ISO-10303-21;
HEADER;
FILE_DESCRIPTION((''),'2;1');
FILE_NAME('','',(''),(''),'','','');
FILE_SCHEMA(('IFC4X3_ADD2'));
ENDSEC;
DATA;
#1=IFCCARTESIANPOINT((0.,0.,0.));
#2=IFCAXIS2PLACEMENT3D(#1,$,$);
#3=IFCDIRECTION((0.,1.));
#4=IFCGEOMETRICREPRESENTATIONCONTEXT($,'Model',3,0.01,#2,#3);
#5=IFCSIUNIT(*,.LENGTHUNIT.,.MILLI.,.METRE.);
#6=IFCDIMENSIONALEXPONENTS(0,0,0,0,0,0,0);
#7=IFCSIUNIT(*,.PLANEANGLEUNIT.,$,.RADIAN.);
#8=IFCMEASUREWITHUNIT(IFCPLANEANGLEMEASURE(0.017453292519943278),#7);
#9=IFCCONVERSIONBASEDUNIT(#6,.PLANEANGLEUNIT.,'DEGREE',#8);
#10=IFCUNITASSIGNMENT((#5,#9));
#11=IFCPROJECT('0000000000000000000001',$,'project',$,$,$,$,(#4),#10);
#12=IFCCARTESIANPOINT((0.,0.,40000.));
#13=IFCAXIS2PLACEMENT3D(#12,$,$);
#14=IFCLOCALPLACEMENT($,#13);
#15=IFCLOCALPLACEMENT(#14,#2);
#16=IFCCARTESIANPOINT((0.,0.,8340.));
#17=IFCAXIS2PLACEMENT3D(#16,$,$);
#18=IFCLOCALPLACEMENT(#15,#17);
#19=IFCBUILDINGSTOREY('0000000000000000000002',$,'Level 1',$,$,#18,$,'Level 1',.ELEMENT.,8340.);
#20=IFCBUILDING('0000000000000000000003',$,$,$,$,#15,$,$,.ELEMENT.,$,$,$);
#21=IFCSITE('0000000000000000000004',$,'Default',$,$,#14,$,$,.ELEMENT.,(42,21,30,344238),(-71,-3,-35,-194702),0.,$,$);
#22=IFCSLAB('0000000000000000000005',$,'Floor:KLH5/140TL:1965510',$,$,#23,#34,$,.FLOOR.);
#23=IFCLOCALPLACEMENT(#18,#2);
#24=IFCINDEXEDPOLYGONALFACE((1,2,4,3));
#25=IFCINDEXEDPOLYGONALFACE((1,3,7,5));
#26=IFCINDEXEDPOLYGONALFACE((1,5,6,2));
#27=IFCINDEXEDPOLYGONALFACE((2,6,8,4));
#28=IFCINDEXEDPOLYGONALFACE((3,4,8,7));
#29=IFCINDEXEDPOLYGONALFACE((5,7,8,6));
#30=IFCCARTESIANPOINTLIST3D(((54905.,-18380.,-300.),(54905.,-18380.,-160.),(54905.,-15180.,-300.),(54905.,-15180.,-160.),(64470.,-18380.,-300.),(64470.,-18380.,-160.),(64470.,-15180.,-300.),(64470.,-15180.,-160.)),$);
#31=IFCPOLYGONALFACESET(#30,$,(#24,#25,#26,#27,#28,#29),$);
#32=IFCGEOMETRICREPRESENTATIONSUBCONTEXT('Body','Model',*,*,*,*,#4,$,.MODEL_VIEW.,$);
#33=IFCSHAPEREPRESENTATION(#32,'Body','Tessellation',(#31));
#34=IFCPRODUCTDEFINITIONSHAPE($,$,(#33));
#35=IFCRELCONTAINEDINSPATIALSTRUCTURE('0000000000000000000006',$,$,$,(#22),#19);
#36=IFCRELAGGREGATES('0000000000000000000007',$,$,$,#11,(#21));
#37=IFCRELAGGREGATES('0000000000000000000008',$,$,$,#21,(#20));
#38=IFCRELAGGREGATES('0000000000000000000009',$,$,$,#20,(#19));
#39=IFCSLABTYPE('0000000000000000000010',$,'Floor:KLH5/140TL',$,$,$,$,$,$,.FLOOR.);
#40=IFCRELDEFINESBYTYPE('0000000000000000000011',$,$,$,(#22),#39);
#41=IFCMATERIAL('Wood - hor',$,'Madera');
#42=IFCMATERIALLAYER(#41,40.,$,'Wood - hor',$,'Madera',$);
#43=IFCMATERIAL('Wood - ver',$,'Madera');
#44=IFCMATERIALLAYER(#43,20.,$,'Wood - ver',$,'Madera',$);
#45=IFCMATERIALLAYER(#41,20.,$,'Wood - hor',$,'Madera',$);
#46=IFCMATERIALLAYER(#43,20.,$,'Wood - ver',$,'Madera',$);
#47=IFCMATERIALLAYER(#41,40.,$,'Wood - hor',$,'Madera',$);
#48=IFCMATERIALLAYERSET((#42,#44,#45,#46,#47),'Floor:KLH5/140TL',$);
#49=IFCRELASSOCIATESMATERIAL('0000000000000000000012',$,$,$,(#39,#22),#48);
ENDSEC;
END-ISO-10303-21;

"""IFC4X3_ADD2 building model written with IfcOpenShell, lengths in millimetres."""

from ifc_helpers import new_model, entity, si_unit, converted_unit, direction, frame, frame_2d, origin, place, context, subcontext, project, spatial, rectangle, extrude, material, layer, layer_set, layer_usage, type_object, element, save


model = new_model("IFC4X3_ADD2")

# Units and contexts
model_context = context("Model", 3, precision=0.01, world=origin(), true_north=direction((0.0, 1.0)))
body_context = subcontext(model_context, "Body", "Model", "MODEL_VIEW")
ifc_project = project(units=[si_unit("LENGTHUNIT", "METRE", prefix="MILLI"), converted_unit("PLANEANGLEUNIT", "DEGREE", entity("IfcPlaneAngleMeasure", 0.017453292519943278), si_unit("PLANEANGLEUNIT", "RADIAN"), dimensions=[0, 0, 0, 0, 0, 0, 0])], contexts=[model_context])

# Site, building, storey
site_placement = place(None, frame((0.0, 0.0, 40000.0)))
site = spatial("IfcSite", under=ifc_project, at=site_placement, Name="Default", CompositionType="ELEMENT", RefLatitude=(42, 21, 30, 344238), RefLongitude=(-71, -3, -35, -194702), RefElevation=0.0)
building_placement = place(site_placement, origin())
building = spatial("IfcBuilding", under=site, at=building_placement, CompositionType="ELEMENT")
storey_placement = place(building_placement, frame((0.0, 0.0, 8340.0)))
storey = spatial("IfcBuildingStorey", under=building, at=storey_placement, Name="Level 1", LongName="Level 1", CompositionType="ELEMENT", Elevation=8340.0)

# Slab
ifc_material_1 = material(Name="Wood - hor", Category="Madera")
ifc_layer_1 = layer(ifc_material_1, 40.0, Name="Wood - hor", Category="Madera")
ifc_material_2 = material(Name="Wood - ver", Category="Madera")
ifc_layer_2 = layer(ifc_material_2, 20.0, Name="Wood - ver", Category="Madera")
ifc_layer_3 = layer(ifc_material_1, 20.0, Name="Wood - hor", Category="Madera")
ifc_layer_4 = layer(ifc_material_2, 20.0, Name="Wood - ver", Category="Madera")
ifc_layer_5 = layer(ifc_material_1, 40.0, Name="Wood - hor", Category="Madera")
ifc_layer_set = layer_set([ifc_layer_1, ifc_layer_2, ifc_layer_3, ifc_layer_4, ifc_layer_5], Name="Floor:KLH5/140TL")
slab_type = type_object("IfcSlabType", Name="Floor:KLH5/140TL", PredefinedType="FLOOR", material=ifc_layer_set)
ifc_layer_usage_1 = layer_usage(ifc_layer_set, "AXIS3", "POSITIVE", 0.0)
slab_1_placement = place(storey_placement, origin())
element("IfcSlab", 1, at=slab_1_placement, inside=storey, type_object=slab_type, material=ifc_layer_usage_1, Name="Floor:KLH5/140TL:1965510", PredefinedType="FLOOR", context=body_context, shape_type="SweptSolid", body=[
    extrude(rectangle(XDim=3200.0, YDim=9565.0, at=frame_2d((0.0, 0.0), x_axis=(1.0, 0.0))), frame((59687.5, -16780.0, -160.0), z_axis=(0.0, 0.0, -1.0), x_axis=(0.0, 1.0, 0.0)), (0.0, 0.0, 1.0), 140.0),
])

save(model, "model.ifc")
